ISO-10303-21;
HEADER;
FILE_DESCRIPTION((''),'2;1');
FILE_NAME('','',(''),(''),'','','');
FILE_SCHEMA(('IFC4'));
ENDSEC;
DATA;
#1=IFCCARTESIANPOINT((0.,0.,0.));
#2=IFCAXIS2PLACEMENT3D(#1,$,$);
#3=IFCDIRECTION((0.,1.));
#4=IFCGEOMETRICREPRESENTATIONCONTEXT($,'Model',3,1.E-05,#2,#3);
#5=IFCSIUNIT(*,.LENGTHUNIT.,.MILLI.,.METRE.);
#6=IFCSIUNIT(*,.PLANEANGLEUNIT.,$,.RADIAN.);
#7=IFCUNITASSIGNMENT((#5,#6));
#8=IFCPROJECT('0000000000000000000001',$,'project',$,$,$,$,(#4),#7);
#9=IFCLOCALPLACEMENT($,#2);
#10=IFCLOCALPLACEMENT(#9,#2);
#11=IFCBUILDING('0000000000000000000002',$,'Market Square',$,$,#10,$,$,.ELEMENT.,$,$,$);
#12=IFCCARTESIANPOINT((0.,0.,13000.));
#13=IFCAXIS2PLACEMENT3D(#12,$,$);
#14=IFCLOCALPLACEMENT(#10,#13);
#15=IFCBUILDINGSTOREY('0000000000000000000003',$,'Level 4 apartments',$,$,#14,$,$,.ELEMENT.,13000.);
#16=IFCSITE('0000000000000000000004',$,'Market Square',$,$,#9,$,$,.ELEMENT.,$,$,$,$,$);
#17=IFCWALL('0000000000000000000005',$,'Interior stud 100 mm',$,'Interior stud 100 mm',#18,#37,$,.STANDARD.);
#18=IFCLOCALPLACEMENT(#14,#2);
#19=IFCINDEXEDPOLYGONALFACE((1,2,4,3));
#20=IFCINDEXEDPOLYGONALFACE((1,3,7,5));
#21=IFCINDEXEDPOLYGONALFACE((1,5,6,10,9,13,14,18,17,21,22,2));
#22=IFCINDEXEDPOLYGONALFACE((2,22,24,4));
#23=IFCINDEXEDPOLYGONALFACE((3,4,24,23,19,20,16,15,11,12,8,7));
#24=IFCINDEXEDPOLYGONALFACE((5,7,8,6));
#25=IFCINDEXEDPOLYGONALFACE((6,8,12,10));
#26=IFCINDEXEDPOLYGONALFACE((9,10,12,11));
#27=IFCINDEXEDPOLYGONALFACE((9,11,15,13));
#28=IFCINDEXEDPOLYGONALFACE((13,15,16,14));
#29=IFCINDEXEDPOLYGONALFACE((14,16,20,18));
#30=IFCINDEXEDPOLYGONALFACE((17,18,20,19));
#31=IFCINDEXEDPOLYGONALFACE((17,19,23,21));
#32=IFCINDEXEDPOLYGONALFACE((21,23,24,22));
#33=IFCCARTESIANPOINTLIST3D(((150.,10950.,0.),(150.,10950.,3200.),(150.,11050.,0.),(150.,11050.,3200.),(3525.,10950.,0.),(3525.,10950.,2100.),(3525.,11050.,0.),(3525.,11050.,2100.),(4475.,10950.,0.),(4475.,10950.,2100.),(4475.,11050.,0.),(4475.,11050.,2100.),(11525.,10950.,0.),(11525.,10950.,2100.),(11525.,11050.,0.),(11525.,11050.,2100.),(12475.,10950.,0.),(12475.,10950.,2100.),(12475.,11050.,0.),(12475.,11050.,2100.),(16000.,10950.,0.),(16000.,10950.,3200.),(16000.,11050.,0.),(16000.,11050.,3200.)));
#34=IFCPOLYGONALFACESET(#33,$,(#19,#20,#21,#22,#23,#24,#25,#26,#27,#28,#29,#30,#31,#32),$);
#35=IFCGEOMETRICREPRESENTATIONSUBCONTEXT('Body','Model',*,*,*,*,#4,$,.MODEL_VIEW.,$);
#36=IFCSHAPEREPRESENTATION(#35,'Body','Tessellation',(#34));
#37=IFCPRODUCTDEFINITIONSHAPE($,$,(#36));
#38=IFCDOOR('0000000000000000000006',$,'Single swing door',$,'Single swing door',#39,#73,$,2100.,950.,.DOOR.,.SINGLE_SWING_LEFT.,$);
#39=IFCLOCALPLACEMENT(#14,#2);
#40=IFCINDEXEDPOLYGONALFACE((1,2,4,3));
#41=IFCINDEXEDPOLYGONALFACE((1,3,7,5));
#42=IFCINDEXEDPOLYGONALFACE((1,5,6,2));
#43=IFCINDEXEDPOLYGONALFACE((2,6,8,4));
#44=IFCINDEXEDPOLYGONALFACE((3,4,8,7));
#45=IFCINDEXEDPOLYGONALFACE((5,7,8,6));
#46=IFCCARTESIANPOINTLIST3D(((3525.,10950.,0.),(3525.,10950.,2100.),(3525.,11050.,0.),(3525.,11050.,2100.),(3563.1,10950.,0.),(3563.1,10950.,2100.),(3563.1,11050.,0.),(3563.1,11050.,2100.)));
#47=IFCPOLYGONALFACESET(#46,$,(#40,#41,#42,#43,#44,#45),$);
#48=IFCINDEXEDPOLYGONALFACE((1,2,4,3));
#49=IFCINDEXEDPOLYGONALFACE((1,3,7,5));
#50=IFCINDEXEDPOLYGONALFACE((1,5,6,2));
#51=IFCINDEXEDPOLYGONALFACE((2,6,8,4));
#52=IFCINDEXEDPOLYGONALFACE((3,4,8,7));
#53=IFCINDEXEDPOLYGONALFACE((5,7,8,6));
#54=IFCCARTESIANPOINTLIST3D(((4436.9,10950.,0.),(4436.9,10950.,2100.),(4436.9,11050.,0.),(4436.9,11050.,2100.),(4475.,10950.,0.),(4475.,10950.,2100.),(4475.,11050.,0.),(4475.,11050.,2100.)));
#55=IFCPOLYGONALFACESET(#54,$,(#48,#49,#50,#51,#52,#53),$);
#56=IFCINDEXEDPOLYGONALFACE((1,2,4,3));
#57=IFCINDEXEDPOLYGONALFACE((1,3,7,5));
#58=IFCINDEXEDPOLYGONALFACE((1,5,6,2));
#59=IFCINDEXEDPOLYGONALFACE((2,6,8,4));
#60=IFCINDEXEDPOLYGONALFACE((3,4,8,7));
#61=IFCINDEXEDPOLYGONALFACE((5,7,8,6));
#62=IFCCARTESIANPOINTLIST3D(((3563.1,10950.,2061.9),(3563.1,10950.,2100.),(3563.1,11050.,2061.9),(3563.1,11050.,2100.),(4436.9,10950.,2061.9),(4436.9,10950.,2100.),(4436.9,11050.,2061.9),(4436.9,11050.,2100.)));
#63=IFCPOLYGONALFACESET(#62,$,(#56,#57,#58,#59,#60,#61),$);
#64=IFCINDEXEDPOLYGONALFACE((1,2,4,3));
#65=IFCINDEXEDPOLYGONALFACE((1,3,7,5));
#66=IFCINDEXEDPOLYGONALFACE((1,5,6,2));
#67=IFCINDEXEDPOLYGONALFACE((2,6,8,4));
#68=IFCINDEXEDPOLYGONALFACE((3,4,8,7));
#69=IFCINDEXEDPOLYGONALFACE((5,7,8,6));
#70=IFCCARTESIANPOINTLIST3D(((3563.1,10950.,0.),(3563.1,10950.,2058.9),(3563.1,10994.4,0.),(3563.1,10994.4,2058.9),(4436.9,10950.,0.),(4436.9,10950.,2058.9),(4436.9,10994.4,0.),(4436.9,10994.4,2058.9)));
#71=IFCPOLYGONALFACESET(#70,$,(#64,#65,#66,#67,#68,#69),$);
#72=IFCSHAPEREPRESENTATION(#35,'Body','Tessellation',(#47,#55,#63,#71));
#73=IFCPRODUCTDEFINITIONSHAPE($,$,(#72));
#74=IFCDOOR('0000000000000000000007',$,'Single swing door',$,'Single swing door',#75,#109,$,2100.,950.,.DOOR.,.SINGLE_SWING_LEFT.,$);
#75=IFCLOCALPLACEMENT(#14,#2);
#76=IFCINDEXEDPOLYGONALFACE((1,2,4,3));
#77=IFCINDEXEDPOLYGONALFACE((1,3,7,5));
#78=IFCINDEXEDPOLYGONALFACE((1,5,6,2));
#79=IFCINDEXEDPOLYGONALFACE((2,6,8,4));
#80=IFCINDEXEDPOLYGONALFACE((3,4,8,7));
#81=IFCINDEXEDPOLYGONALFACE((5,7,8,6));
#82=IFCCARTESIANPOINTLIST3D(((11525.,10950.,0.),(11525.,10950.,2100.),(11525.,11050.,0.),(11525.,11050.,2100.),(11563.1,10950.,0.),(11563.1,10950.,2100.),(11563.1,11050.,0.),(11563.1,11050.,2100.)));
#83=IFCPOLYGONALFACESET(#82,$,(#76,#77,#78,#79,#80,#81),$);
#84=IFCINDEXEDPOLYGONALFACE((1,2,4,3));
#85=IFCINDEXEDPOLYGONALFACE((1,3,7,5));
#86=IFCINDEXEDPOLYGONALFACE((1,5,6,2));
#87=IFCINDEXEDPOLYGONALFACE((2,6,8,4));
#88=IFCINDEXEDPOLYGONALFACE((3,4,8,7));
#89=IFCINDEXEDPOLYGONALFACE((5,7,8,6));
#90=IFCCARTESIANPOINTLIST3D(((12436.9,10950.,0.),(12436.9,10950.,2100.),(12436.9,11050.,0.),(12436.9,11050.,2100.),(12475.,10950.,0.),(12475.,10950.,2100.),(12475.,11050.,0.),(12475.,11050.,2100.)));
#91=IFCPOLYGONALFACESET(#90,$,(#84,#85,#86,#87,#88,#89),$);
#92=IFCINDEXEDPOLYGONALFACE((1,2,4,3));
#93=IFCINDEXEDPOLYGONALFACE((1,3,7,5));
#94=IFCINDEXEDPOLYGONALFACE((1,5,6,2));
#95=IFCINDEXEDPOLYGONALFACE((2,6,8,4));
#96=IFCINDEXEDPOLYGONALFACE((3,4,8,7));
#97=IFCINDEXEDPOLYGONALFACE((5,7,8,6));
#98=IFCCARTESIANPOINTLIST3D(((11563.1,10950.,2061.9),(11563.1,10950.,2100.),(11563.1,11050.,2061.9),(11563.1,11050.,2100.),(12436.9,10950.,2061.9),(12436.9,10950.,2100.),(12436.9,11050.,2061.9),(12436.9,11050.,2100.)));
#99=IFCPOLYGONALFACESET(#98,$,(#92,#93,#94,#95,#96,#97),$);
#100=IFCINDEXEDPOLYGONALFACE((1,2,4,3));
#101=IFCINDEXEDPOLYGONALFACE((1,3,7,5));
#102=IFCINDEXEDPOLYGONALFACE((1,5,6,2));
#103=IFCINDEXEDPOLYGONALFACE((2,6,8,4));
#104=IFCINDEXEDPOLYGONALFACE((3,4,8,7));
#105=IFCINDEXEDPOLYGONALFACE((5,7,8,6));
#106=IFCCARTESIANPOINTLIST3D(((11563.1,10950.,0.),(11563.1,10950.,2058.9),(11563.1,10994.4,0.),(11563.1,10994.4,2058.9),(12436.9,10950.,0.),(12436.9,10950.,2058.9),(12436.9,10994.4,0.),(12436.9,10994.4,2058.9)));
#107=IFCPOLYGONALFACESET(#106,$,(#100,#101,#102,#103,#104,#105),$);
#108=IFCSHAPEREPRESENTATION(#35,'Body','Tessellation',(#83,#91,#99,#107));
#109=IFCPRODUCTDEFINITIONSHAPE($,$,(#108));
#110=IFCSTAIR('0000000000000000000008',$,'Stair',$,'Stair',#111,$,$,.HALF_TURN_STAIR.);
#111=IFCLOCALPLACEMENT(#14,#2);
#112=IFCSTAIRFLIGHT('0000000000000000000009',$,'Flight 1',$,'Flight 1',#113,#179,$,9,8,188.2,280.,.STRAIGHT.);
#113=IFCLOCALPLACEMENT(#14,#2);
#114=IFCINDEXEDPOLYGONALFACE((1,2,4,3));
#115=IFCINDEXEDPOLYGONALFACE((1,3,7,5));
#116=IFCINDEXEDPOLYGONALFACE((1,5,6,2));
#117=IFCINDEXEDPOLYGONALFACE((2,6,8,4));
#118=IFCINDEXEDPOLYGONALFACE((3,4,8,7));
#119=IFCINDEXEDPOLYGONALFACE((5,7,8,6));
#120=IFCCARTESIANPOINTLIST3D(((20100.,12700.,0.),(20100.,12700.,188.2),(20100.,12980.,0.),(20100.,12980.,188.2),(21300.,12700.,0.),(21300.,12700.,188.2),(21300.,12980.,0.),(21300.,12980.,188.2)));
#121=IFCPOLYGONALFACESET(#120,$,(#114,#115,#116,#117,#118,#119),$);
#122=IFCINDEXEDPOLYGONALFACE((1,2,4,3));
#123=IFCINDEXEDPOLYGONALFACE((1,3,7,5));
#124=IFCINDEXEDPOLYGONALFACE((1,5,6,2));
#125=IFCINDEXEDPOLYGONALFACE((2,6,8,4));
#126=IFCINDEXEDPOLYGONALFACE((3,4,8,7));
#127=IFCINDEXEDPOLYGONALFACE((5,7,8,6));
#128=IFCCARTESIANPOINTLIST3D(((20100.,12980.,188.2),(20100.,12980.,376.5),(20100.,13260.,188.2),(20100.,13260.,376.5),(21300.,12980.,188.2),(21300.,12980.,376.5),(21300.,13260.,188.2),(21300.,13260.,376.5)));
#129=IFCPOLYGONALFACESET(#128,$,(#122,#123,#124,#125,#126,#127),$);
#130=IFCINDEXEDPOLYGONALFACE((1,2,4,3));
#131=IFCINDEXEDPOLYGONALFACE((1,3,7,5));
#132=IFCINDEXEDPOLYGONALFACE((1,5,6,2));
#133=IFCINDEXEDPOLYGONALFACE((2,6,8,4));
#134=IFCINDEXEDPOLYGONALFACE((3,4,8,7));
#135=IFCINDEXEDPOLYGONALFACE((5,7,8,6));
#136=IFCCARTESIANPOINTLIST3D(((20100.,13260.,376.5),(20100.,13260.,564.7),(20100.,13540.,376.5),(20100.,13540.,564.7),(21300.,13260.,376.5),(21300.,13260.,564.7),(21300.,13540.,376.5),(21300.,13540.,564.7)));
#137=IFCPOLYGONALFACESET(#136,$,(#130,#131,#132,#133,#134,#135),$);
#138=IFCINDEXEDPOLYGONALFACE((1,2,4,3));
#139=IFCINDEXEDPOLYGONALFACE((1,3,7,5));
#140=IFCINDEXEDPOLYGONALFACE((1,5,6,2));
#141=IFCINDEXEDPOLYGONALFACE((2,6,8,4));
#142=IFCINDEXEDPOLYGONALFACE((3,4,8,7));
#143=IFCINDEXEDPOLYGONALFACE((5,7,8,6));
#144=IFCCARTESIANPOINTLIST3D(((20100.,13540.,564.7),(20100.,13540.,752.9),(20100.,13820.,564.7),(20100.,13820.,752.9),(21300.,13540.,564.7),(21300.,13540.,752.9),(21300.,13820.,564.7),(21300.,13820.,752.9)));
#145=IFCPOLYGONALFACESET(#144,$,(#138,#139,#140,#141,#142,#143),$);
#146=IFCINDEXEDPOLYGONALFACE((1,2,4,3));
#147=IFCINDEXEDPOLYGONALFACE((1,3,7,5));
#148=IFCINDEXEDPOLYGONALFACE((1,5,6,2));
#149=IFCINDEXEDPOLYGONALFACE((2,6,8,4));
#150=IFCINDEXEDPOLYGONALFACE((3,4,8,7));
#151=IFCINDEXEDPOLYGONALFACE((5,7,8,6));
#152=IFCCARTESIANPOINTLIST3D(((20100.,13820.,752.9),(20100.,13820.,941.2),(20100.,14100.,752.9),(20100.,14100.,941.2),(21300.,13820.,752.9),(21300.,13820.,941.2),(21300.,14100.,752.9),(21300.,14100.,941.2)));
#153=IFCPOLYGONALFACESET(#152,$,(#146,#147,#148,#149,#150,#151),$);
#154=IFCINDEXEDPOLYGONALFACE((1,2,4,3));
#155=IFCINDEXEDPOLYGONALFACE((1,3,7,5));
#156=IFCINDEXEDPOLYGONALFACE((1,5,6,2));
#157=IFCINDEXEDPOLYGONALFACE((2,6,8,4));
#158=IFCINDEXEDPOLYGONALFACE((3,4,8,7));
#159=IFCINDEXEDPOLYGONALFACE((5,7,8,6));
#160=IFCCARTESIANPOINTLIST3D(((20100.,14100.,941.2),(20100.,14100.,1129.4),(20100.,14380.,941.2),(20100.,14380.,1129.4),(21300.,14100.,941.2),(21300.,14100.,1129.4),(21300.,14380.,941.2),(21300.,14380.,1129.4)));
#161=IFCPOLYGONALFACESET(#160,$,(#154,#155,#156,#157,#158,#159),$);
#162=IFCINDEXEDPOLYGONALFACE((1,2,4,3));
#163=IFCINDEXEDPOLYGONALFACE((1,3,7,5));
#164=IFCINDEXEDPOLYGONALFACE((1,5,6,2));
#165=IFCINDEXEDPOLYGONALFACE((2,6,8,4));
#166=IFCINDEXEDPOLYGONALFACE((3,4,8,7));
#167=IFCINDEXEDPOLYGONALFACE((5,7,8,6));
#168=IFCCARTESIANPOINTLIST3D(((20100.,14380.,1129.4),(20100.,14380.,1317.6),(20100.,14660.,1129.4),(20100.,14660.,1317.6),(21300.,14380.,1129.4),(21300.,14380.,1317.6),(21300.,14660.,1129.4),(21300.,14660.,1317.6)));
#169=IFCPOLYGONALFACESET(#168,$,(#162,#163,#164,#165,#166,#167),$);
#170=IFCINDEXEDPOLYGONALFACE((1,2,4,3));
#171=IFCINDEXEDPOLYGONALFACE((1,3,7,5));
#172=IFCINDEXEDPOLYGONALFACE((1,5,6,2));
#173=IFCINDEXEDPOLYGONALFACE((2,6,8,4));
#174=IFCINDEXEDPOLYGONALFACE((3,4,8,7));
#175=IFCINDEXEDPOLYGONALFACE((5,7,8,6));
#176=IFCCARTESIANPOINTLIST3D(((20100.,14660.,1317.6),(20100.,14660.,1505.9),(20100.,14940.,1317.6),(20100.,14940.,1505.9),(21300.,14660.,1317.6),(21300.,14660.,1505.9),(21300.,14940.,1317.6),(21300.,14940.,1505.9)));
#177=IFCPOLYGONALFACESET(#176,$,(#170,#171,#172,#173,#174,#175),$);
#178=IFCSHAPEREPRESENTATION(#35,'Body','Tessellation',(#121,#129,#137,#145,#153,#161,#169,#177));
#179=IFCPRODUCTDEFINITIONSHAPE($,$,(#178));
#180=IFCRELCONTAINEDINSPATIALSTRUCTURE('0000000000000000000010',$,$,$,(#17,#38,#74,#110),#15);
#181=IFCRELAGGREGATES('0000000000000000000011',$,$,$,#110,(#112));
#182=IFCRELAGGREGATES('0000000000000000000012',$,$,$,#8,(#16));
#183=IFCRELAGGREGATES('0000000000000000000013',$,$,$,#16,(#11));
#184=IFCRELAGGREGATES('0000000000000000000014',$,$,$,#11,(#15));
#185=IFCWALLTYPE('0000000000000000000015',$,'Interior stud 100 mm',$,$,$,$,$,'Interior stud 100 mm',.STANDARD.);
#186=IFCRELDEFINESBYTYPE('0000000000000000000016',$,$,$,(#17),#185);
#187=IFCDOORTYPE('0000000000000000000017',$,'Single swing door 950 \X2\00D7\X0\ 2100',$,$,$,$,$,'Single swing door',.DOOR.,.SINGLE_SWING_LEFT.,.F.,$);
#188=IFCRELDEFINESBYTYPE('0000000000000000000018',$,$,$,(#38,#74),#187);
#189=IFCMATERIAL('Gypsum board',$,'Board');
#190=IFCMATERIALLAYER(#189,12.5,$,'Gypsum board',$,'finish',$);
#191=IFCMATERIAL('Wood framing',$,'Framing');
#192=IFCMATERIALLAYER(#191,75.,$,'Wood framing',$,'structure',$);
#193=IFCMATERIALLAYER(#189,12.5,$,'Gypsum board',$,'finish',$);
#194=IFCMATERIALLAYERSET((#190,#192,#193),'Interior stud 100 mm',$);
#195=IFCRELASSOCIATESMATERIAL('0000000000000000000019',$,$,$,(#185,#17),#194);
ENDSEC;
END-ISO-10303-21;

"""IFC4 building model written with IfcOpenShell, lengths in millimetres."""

from ifc_helpers import new_model, si_unit, direction, frame, origin, origin_with_axes, place, context, subcontext, project, spatial, polyline, outline, extrude, material, layer, layer_set, layer_usage, type_object, element, fill, aggregate, save


model = new_model("IFC4")

# Units and contexts
model_context = context("Model", 3, precision=1e-05, world=origin(), true_north=direction((0.0, 1.0)))
body_context = subcontext(model_context, "Body", "Model", "MODEL_VIEW")
ifc_project = project(units=[si_unit("LENGTHUNIT", "METRE", prefix="MILLI"), si_unit("PLANEANGLEUNIT", "RADIAN")], contexts=[model_context])

# Site, building, storey
site_placement = place(None, origin())
site = spatial("IfcSite", under=ifc_project, at=site_placement, Name="Market Square", CompositionType="ELEMENT")
building_placement = place(site_placement, origin())
building = spatial("IfcBuilding", under=site, at=building_placement, Name="Market Square", CompositionType="ELEMENT")
storey_placement = place(building_placement, frame((0.0, 0.0, 13000.0)))
storey = spatial("IfcBuildingStorey", under=building, at=storey_placement, Name="Level 4 apartments", CompositionType="ELEMENT", Elevation=13000.0)

# Wall, openings, doors
ifc_material_1 = material(Name="Gypsum board", Category="Board")
ifc_layer_1 = layer(ifc_material_1, 12.5, Name="Gypsum board", Category="finish")
ifc_material_2 = material(Name="Wood framing", Category="Framing")
ifc_layer_2 = layer(ifc_material_2, 75.0, Name="Wood framing", Category="structure")
ifc_layer_3 = layer(ifc_material_1, 12.5, Name="Gypsum board", Category="finish")
ifc_layer_set_1 = layer_set([ifc_layer_1, ifc_layer_2, ifc_layer_3], Name="Interior stud 100 mm")
wall_type_1 = type_object("IfcWallType", Name="Interior stud 100 mm", ElementType="Interior stud 100 mm", PredefinedType="STANDARD", material=ifc_layer_set_1)
door_type = type_object("IfcDoorType", Name="Single swing door 950 × 2100", ElementType="Single swing door", OperationType="SINGLE_SWING_LEFT", ParameterTakesPrecedence=False, PredefinedType="DOOR")
ifc_layer_usage_1 = layer_usage(ifc_layer_set_1, "AXIS2", "NEGATIVE", 50.0)
wall_1_placement = place(storey_placement, frame((0.0, 11000.0, 0.0), z_axis=(0.0, 0.0, 1.0), x_axis=(1.0, 0.0, 0.0)))
wall_1 = element("IfcWall", 1, at=wall_1_placement, inside=storey, type_object=wall_type_1, material=ifc_layer_usage_1, Name="Interior stud 100 mm", ObjectType="Interior stud 100 mm", PredefinedType="STANDARD", context=body_context, shape_type="SweptSolid", body=[
    extrude(outline(polyline([(150.0, -50.0), (16000.0, -50.0), (16000.0, 50.0), (150.0, 50.0), (150.0, -50.0)])), origin(), (0.0, 0.0, 1.0), 3200.0),
])
opening_1_placement = place(wall_1_placement, frame((3525.0, 0.0, 0.0), z_axis=(0.0, 0.0, 1.0), x_axis=(1.0, 0.0, 0.0)))
opening_1 = element("IfcOpeningElement", 2, at=opening_1_placement, cuts=wall_1, PredefinedType="OPENING", context=body_context, shape_type="SweptSolid", body=[
    extrude(outline(polyline([(0.0, -60.0), (950.0, -60.0), (950.0, 60.0), (0.0, 60.0), (0.0, -60.0)])), origin(), (0.0, 0.0, 1.0), 2100.0),
])
opening_2_placement = place(wall_1_placement, frame((11525.0, 0.0, 0.0), z_axis=(0.0, 0.0, 1.0), x_axis=(1.0, 0.0, 0.0)))
opening_2 = element("IfcOpeningElement", 3, at=opening_2_placement, cuts=wall_1, PredefinedType="OPENING", context=body_context, shape_type="SweptSolid", body=[
    extrude(outline(polyline([(0.0, -60.0), (950.0, -60.0), (950.0, 60.0), (0.0, 60.0), (0.0, -60.0)])), origin(), (0.0, 0.0, 1.0), 2100.0),
])
door_1_placement = place(opening_1_placement, origin_with_axes())
door_1 = element("IfcDoor", 4, at=door_1_placement, inside=storey, type_object=door_type, Name="Single swing door", ObjectType="Single swing door", OperationType="SINGLE_SWING_LEFT", OverallHeight=2100.0, OverallWidth=950.0, PredefinedType="DOOR", context=body_context, shape_type="SweptSolid", body=[
    extrude(outline(polyline([(0.0, -50.0), (38.1, -50.0), (38.1, 50.0), (0.0, 50.0), (0.0, -50.0)])), origin(), (0.0, 0.0, 1.0), 2100.0),
    extrude(outline(polyline([(911.9, -50.0), (950.0, -50.0), (950.0, 50.0), (911.9, 50.0), (911.9, -50.0)])), origin(), (0.0, 0.0, 1.0), 2100.0),
    extrude(outline(polyline([(38.1, -50.0), (911.9, -50.0), (911.9, 50.0), (38.1, 50.0), (38.1, -50.0)])), frame((0.0, 0.0, 2061.9)), (0.0, 0.0, 1.0), 38.1),
    extrude(outline(polyline([(38.1, -50.0), (911.9, -50.0), (911.9, -5.5), (38.1, -5.5), (38.1, -50.0)])), origin(), (0.0, 0.0, 1.0), 2058.9),
])
fill(opening_1, door_1)
door_2_placement = place(opening_2_placement, origin_with_axes())
door_2 = element("IfcDoor", 5, at=door_2_placement, inside=storey, type_object=door_type, Name="Single swing door", ObjectType="Single swing door", OperationType="SINGLE_SWING_LEFT", OverallHeight=2100.0, OverallWidth=950.0, PredefinedType="DOOR", context=body_context, shape_type="SweptSolid", body=[
    extrude(outline(polyline([(0.0, -50.0), (38.1, -50.0), (38.1, 50.0), (0.0, 50.0), (0.0, -50.0)])), origin(), (0.0, 0.0, 1.0), 2100.0),
    extrude(outline(polyline([(911.9, -50.0), (950.0, -50.0), (950.0, 50.0), (911.9, 50.0), (911.9, -50.0)])), origin(), (0.0, 0.0, 1.0), 2100.0),
    extrude(outline(polyline([(38.1, -50.0), (911.9, -50.0), (911.9, 50.0), (38.1, 50.0), (38.1, -50.0)])), frame((0.0, 0.0, 2061.9)), (0.0, 0.0, 1.0), 38.1),
    extrude(outline(polyline([(38.1, -50.0), (911.9, -50.0), (911.9, -5.5), (38.1, -5.5), (38.1, -50.0)])), origin(), (0.0, 0.0, 1.0), 2058.9),
])
fill(opening_2, door_2)

# Stair, stair flight
stair_placement = place(storey_placement, origin_with_axes())
stair = element("IfcStair", 6, at=stair_placement, inside=storey, Name="Stair", ObjectType="Stair", PredefinedType="HALF_TURN_STAIR")
stair_flight_placement = place(storey_placement, origin_with_axes())
stair_flight = element("IfcStairFlight", 7, at=stair_flight_placement, Name="Flight 1", ObjectType="Flight 1", NumberOfRisers=9, NumberOfTreads=8, PredefinedType="STRAIGHT", RiserHeight=188.2, TreadLength=280.0, context=body_context, shape_type="SweptSolid", body=[
    extrude(outline(polyline([(21300.0, 12700.0), (21300.0, 12980.0), (20100.0, 12980.0), (20100.0, 12700.0), (21300.0, 12700.0)])), origin(), (0.0, 0.0, 1.0), 188.2),
    extrude(outline(polyline([(21300.0, 12980.0), (21300.0, 13260.0), (20100.0, 13260.0), (20100.0, 12980.0), (21300.0, 12980.0)])), frame((0.0, 0.0, 188.2)), (0.0, 0.0, 1.0), 188.2),
    extrude(outline(polyline([(21300.0, 13260.0), (21300.0, 13540.0), (20100.0, 13540.0), (20100.0, 13260.0), (21300.0, 13260.0)])), frame((0.0, 0.0, 376.5)), (0.0, 0.0, 1.0), 188.2),
    extrude(outline(polyline([(21300.0, 13540.0), (21300.0, 13820.0), (20100.0, 13820.0), (20100.0, 13540.0), (21300.0, 13540.0)])), frame((0.0, 0.0, 564.7)), (0.0, 0.0, 1.0), 188.2),
    extrude(outline(polyline([(21300.0, 13820.0), (21300.0, 14100.0), (20100.0, 14100.0), (20100.0, 13820.0), (21300.0, 13820.0)])), frame((0.0, 0.0, 752.9)), (0.0, 0.0, 1.0), 188.2),
    extrude(outline(polyline([(21300.0, 14100.0), (21300.0, 14380.0), (20100.0, 14380.0), (20100.0, 14100.0), (21300.0, 14100.0)])), frame((0.0, 0.0, 941.2)), (0.0, 0.0, 1.0), 188.2),
    extrude(outline(polyline([(21300.0, 14380.0), (21300.0, 14660.0), (20100.0, 14660.0), (20100.0, 14380.0), (21300.0, 14380.0)])), frame((0.0, 0.0, 1129.4)), (0.0, 0.0, 1.0), 188.2),
    extrude(outline(polyline([(21300.0, 14660.0), (21300.0, 14940.0), (20100.0, 14940.0), (20100.0, 14660.0), (21300.0, 14660.0)])), frame((0.0, 0.0, 1317.6)), (0.0, 0.0, 1.0), 188.2),
])
aggregate(stair, [stair_flight])

save(model, "model.ifc")
